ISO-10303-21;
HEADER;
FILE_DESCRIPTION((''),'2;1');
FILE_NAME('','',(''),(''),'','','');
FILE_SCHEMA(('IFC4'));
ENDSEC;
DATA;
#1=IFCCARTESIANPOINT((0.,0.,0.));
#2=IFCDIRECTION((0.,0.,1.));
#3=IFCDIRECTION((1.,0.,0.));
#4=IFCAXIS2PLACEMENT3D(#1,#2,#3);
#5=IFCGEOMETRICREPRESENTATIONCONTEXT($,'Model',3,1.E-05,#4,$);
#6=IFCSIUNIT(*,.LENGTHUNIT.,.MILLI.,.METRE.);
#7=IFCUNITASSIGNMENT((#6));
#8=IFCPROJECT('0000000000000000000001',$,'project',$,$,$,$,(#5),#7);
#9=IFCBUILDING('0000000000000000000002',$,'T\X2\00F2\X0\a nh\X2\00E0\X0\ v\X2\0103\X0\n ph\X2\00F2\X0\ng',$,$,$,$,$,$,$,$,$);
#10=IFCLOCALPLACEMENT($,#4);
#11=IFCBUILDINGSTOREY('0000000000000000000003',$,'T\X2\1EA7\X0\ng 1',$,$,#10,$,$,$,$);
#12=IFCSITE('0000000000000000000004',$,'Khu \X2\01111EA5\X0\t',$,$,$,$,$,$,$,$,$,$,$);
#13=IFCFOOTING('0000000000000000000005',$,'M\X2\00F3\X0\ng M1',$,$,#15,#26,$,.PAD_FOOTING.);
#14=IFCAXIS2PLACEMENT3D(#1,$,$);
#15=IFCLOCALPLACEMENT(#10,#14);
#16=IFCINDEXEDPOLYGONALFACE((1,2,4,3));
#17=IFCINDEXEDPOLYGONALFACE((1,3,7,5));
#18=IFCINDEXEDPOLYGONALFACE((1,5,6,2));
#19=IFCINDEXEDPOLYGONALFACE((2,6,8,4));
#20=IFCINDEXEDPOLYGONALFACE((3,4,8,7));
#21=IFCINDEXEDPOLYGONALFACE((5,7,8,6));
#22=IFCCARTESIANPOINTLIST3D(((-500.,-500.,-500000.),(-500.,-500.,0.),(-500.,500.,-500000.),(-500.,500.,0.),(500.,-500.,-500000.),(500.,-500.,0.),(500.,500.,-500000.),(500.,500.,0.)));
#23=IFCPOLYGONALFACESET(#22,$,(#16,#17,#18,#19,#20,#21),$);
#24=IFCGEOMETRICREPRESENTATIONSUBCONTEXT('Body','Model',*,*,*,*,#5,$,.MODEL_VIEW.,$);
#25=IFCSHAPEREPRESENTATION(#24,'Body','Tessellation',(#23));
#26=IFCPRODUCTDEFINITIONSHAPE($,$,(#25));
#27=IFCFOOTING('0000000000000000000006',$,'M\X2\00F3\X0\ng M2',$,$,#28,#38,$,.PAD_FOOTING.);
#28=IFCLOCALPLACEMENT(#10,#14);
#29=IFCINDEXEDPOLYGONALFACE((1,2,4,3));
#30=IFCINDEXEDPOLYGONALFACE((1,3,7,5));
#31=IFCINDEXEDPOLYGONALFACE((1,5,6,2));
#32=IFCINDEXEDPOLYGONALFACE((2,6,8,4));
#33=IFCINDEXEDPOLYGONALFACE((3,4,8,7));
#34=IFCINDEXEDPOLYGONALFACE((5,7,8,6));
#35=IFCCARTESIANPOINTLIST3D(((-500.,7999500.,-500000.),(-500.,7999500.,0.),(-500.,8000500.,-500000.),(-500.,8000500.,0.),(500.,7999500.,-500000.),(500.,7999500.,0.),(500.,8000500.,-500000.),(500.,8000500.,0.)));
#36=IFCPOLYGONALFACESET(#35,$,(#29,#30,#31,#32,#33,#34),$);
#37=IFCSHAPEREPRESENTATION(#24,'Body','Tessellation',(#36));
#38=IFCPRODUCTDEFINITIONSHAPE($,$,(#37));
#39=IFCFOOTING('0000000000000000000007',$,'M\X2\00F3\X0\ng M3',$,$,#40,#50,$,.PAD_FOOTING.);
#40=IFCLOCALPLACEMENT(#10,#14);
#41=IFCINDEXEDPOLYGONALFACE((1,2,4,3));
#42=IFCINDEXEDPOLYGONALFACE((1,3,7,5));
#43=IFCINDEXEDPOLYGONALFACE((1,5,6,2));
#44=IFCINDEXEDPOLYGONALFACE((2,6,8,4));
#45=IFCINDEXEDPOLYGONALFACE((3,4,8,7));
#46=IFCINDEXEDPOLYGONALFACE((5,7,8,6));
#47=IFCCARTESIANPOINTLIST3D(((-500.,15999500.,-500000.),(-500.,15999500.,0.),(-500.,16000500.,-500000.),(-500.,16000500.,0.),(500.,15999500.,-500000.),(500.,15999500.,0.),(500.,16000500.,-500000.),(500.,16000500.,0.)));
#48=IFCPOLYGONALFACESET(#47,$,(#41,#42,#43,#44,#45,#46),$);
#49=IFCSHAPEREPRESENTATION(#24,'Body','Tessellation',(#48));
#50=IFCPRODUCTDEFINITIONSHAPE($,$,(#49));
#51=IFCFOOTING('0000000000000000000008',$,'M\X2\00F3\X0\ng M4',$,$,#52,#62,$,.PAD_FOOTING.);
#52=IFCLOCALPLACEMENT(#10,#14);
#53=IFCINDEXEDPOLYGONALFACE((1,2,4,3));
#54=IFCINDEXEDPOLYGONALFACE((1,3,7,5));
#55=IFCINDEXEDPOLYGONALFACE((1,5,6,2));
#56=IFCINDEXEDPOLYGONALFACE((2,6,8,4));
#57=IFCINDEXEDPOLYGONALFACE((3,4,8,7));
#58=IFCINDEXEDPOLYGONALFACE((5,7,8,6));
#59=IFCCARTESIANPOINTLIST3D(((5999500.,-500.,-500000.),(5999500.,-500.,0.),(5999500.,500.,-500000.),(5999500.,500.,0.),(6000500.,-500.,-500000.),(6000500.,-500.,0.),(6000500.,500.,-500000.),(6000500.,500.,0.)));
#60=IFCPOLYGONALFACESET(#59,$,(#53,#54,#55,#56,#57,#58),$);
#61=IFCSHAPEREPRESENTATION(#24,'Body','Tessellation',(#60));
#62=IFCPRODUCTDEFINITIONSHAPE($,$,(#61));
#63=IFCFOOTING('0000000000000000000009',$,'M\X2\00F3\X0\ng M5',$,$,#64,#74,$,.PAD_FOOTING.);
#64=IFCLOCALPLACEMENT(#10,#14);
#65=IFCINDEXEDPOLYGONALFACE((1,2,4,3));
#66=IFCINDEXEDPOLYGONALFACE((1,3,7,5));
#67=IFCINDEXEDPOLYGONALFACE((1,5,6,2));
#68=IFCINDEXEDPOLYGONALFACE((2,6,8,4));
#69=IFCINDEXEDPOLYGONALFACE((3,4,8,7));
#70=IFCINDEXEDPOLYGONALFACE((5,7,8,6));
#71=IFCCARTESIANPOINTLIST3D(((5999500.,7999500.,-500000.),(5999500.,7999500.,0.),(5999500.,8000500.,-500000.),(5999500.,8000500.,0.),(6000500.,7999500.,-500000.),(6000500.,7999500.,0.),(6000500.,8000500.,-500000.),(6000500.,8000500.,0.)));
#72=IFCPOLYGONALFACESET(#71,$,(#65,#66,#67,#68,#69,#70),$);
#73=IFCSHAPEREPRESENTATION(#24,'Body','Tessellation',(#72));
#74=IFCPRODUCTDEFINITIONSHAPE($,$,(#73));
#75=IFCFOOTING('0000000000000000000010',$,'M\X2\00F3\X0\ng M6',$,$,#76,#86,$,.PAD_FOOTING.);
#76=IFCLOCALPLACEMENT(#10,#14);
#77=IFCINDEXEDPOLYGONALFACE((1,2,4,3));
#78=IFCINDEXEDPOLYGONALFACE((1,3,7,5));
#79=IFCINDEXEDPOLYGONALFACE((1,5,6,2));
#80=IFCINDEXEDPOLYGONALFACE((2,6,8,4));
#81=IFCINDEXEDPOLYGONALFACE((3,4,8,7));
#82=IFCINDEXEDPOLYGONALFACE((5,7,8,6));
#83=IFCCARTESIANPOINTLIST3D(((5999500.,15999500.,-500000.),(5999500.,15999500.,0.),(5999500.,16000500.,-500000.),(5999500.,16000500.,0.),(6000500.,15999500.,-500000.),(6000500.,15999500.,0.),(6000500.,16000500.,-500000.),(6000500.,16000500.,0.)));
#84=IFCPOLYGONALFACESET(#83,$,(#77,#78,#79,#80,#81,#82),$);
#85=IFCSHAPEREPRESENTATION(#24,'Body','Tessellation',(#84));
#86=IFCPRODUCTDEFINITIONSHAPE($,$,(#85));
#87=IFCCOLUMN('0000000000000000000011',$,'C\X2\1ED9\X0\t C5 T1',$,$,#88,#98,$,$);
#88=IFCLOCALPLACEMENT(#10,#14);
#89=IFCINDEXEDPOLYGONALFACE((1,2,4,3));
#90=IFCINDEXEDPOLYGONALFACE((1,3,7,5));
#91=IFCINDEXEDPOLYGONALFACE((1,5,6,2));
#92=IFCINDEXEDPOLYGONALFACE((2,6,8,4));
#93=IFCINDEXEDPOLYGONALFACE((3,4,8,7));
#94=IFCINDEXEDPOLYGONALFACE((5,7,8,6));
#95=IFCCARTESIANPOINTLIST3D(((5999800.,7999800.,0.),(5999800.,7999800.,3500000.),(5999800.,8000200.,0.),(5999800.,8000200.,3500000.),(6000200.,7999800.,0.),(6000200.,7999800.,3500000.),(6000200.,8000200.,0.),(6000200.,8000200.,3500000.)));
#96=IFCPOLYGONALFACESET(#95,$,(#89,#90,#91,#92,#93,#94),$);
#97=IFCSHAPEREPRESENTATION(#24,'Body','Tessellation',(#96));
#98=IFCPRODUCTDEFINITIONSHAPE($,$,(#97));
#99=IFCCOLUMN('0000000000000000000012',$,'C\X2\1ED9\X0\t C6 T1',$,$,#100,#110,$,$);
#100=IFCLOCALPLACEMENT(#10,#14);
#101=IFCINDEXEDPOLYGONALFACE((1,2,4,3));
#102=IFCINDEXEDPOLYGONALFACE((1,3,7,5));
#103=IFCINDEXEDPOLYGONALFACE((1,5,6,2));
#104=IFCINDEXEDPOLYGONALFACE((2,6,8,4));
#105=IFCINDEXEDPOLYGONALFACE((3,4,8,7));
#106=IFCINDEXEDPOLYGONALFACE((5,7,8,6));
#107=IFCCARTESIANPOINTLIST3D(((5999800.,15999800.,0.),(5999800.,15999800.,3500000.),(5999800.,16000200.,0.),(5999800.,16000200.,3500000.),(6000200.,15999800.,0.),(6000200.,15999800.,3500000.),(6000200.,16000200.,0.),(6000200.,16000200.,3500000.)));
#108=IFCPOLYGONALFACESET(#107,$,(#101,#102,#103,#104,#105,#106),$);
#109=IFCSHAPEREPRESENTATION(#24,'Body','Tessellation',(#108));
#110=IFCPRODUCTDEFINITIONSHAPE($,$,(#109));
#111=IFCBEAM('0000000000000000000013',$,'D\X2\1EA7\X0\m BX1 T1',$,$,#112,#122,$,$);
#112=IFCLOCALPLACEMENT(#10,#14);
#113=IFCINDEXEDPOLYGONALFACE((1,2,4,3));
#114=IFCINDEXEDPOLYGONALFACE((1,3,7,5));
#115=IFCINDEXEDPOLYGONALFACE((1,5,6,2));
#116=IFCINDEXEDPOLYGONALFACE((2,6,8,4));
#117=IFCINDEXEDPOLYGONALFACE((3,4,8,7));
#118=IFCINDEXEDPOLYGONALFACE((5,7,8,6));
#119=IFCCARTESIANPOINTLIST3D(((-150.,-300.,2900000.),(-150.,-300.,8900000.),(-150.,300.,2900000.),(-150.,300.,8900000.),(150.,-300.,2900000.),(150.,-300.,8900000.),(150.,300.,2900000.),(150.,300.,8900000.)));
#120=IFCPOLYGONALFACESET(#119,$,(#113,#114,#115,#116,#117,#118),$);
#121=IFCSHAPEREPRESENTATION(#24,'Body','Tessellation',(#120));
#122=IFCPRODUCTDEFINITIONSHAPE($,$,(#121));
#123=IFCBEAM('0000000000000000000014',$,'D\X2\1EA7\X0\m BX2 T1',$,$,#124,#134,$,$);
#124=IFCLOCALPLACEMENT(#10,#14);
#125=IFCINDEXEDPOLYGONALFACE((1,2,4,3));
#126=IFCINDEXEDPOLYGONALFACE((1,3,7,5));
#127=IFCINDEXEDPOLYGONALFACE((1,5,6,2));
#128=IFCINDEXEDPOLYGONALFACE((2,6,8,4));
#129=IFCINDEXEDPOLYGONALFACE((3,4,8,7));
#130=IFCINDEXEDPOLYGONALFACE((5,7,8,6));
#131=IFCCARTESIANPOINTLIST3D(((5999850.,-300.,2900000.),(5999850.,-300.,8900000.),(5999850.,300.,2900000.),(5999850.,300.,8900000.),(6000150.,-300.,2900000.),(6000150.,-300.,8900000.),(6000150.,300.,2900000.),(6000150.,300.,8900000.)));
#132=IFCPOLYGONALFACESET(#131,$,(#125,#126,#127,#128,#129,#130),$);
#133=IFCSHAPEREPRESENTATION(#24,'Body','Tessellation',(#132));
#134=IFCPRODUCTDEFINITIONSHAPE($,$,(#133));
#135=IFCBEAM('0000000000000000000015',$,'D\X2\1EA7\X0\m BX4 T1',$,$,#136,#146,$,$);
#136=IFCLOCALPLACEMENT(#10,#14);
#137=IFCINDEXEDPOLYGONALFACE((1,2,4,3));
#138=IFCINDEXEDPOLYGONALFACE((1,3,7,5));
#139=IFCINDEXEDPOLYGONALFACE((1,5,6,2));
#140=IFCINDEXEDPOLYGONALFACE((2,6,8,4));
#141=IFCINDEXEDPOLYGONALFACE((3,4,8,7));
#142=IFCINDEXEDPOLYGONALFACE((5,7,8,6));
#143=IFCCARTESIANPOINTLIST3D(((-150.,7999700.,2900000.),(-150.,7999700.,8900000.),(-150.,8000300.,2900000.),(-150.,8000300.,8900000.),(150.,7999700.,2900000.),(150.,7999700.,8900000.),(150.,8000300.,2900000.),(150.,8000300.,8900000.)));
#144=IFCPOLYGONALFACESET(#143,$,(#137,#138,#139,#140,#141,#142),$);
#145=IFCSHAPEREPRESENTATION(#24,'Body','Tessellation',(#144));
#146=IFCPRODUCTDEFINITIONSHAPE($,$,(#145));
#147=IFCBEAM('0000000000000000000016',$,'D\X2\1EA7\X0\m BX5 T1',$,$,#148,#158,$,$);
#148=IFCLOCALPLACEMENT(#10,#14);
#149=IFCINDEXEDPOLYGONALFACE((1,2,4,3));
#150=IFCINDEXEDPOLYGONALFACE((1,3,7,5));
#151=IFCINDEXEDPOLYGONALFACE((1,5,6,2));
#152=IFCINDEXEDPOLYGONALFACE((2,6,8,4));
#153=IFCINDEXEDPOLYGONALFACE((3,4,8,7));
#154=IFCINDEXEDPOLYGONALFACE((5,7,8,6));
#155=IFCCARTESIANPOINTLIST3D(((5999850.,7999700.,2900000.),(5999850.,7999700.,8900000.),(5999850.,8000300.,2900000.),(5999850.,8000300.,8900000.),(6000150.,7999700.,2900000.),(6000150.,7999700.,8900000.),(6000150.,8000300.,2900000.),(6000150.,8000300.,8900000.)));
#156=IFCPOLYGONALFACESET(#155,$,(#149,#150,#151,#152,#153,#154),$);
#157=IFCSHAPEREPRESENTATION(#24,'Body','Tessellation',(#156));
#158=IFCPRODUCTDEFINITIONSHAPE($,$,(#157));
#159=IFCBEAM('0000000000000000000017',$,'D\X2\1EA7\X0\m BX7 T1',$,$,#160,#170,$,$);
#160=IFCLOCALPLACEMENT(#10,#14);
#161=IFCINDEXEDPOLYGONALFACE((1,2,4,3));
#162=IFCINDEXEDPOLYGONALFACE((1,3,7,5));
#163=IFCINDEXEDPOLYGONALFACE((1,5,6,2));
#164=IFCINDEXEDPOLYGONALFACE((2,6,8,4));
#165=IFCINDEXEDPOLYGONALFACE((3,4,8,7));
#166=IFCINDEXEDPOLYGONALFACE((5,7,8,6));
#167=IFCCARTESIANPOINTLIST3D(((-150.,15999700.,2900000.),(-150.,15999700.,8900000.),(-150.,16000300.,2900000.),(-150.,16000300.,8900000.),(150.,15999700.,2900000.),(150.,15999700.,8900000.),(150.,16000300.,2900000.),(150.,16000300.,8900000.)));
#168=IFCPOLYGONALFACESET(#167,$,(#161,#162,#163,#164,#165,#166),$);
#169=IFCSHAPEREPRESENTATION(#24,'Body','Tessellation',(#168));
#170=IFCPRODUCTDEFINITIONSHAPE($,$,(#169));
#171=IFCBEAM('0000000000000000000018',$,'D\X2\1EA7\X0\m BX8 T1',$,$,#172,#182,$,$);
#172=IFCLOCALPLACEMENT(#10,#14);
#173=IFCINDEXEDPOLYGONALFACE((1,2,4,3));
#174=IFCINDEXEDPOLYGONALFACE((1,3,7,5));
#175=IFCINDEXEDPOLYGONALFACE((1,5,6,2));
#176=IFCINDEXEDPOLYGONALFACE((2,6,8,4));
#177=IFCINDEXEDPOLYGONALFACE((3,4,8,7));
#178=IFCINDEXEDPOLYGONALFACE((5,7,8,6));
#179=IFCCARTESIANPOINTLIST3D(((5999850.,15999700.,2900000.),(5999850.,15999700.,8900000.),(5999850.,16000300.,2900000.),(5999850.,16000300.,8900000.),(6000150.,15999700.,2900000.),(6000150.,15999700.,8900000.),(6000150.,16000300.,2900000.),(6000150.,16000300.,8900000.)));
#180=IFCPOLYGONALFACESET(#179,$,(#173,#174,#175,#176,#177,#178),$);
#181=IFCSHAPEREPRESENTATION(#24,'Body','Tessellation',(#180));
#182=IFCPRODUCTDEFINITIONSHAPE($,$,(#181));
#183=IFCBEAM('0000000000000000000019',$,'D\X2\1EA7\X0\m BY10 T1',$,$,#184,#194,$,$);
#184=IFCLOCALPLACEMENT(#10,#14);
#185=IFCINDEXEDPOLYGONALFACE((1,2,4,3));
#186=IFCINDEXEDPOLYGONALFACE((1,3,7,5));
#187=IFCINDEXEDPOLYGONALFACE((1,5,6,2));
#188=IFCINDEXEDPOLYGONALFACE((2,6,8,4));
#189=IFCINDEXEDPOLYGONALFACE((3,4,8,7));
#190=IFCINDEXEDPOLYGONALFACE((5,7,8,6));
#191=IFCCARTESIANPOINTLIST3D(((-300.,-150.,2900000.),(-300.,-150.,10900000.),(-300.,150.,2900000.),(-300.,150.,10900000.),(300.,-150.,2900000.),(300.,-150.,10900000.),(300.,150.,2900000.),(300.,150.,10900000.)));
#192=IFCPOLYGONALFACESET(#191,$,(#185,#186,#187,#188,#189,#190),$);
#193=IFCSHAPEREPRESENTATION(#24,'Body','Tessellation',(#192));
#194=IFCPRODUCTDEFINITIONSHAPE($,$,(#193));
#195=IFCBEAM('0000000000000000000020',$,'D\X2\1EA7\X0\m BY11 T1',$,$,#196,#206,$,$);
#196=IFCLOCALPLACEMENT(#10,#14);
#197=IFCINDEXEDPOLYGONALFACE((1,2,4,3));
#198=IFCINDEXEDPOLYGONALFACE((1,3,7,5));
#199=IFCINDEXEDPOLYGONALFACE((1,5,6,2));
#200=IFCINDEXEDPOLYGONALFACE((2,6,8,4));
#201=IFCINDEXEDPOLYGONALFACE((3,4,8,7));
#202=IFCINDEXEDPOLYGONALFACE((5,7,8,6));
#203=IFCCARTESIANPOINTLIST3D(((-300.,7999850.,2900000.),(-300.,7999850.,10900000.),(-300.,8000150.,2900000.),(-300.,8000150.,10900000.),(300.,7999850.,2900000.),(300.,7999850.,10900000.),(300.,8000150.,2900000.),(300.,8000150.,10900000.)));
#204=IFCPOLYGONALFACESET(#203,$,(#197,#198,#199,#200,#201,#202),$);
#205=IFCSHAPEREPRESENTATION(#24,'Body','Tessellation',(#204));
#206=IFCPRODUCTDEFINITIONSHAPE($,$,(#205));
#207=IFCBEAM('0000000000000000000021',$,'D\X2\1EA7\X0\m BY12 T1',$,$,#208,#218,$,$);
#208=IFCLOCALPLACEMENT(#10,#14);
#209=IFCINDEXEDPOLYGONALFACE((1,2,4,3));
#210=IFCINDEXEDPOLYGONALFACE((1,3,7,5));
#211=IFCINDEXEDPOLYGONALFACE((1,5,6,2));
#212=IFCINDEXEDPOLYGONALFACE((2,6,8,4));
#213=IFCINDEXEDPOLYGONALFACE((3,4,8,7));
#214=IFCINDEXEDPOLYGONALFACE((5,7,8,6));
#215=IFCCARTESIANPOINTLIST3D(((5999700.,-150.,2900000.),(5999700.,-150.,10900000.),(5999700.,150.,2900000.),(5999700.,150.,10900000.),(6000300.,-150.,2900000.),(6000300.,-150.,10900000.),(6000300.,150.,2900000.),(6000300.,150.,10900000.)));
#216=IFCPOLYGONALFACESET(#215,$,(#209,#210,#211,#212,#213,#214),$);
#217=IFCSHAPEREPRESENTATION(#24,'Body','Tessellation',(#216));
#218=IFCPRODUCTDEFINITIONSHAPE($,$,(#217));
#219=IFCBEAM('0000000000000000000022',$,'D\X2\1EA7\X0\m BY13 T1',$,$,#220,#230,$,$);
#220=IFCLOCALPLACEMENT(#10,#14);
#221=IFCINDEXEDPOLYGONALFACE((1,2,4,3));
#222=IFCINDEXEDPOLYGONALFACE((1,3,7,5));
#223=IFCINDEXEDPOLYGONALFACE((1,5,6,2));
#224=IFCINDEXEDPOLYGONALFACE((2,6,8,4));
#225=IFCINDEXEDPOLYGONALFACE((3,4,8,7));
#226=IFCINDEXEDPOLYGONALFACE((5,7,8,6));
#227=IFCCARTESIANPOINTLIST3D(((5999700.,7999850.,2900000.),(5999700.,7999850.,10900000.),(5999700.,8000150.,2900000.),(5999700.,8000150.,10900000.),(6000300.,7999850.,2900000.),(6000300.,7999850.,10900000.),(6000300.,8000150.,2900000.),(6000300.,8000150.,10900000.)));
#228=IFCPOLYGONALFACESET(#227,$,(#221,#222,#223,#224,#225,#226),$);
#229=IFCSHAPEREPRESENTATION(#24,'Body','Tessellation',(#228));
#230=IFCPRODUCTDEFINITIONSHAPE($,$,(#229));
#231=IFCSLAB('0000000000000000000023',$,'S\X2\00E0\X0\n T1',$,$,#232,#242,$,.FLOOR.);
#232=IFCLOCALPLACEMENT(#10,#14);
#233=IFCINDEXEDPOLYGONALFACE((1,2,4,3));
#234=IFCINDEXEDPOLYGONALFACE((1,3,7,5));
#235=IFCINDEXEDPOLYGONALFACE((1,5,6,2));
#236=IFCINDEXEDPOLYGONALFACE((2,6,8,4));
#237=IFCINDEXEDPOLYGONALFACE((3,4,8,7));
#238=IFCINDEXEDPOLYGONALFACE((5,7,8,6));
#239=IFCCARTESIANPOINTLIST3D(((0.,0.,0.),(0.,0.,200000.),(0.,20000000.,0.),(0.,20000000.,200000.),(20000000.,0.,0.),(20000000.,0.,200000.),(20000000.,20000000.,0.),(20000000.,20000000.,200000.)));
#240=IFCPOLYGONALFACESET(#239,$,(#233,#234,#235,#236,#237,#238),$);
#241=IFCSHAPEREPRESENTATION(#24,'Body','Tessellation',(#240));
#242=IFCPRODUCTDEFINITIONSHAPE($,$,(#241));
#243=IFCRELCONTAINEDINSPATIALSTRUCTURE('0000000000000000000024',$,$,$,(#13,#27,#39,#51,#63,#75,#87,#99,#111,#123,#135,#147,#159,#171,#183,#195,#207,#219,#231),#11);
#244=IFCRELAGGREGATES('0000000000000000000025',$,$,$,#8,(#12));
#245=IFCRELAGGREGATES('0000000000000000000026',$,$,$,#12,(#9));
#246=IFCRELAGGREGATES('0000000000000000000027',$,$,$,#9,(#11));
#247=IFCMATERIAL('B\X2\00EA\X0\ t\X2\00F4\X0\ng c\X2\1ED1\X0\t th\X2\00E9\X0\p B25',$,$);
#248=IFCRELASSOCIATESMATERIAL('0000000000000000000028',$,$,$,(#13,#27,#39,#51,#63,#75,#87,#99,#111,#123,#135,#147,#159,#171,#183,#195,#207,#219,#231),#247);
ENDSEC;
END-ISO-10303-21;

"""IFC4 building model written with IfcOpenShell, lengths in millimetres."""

from ifc_helpers import new_model, entity, si_unit, frame, origin_with_axes, place, context, subcontext, project, spatial, indexed_curve, outline, extrude, material, element, save


model = new_model("IFC4")

# Units and contexts
model_context = context("Model", 3, precision=1e-05, world=origin_with_axes())
body_context = subcontext(model_context, "Body", "Model", "MODEL_VIEW")
ifc_project = project(units=[si_unit("LENGTHUNIT", "METRE", prefix="MILLI")], contexts=[model_context])

# Site, building, storey
site = spatial("IfcSite", under=ifc_project, Name="Khu đất")
building = spatial("IfcBuilding", under=site, Name="Tòa nhà văn phòng")
storey_placement = place(None, origin_with_axes())
storey = spatial("IfcBuildingStorey", under=building, at=storey_placement, Name="Tầng 1")

# Footings
ifc_material_1 = material(Name="Bê tông cốt thép B25")
for number, where, z_axis, x_axis, name in (
    (1, (0.0, 0.0, -500000.0), (0.0, 0.0, 1.0), (1.0, 0.0, 0.0), "Móng M1"),
    (2, (0.0, 8000000.0, -500000.0), (0.0, 0.0, 1.0), (1.0, 0.0, 0.0), "Móng M2"),
    (3, (0.0, 16000000.0, -500000.0), (0.0, 0.0, 1.0), (1.0, 0.0, 0.0), "Móng M3"),
    (4, (6000000.0, 0.0, -500000.0), (0.0, 0.0, 1.0), (1.0, 0.0, 0.0), "Móng M4"),
    (5, (6000000.0, 8000000.0, -500000.0), (0.0, 0.0, 1.0), (1.0, 0.0, 0.0), "Móng M5"),
    (6, (6000000.0, 16000000.0, -500000.0), (0.0, 0.0, 1.0), (1.0, 0.0, 0.0), "Móng M6"),
):
    element("IfcFooting", number, at=place(storey_placement, frame(where, z_axis=z_axis, x_axis=x_axis)), inside=storey, material=ifc_material_1, Name=name, PredefinedType="PAD_FOOTING", context=body_context, shape_type="SweptSolid", body=[
        extrude(entity("IfcRectangleProfileDef", None, None, None, 1000.0, 1000.0), origin_with_axes(), (0.0, 0.0, 1.0), 500000.0),
    ])

# Columns
for number, where, z_axis, x_axis, name in (
    (7, (6000000.0, 8000000.0, 0.0), (0.0, 0.0, 1.0), (1.0, 0.0, 0.0), "Cột C5 T1"),
    (8, (6000000.0, 16000000.0, 0.0), (0.0, 0.0, 1.0), (1.0, 0.0, 0.0), "Cột C6 T1"),
):
    element("IfcColumn", number, at=place(storey_placement, frame(where, z_axis=z_axis, x_axis=x_axis)), inside=storey, material=ifc_material_1, Name=name, context=body_context, shape_type="SweptSolid", body=[
        extrude(entity("IfcRectangleProfileDef", None, None, None, 400.0, 400.0), origin_with_axes(), (0.0, 0.0, 1.0), 3500000.0),
    ])

# Beams
for number, where, z_axis, x_axis, name in (
    (9, (0.0, 0.0, 2900000.0), (0.0, 0.0, 1.0), (1.0, 0.0, 0.0), "Dầm BX1 T1"),
    (10, (6000000.0, 0.0, 2900000.0), (0.0, 0.0, 1.0), (1.0, 0.0, 0.0), "Dầm BX2 T1"),
    (11, (0.0, 8000000.0, 2900000.0), (0.0, 0.0, 1.0), (1.0, 0.0, 0.0), "Dầm BX4 T1"),
    (12, (6000000.0, 8000000.0, 2900000.0), (0.0, 0.0, 1.0), (1.0, 0.0, 0.0), "Dầm BX5 T1"),
    (13, (0.0, 16000000.0, 2900000.0), (0.0, 0.0, 1.0), (1.0, 0.0, 0.0), "Dầm BX7 T1"),
    (14, (6000000.0, 16000000.0, 2900000.0), (0.0, 0.0, 1.0), (1.0, 0.0, 0.0), "Dầm BX8 T1"),
):
    element("IfcBeam", number, at=place(storey_placement, frame(where, z_axis=z_axis, x_axis=x_axis)), inside=storey, material=ifc_material_1, Name=name, context=body_context, shape_type="SweptSolid", body=[
        extrude(entity("IfcRectangleProfileDef", None, None, None, 300.0, 600.0), origin_with_axes(), (0.0, 0.0, 1.0), 6000000.0),
    ])
for number, where, z_axis, x_axis, name in (
    (15, (0.0, 0.0, 2900000.0), (0.0, 0.0, 1.0), (0.0, 1.0, 0.0), "Dầm BY10 T1"),
    (16, (0.0, 8000000.0, 2900000.0), (0.0, 0.0, 1.0), (0.0, 1.0, 0.0), "Dầm BY11 T1"),
    (17, (6000000.0, 0.0, 2900000.0), (0.0, 0.0, 1.0), (0.0, 1.0, 0.0), "Dầm BY12 T1"),
    (18, (6000000.0, 8000000.0, 2900000.0), (0.0, 0.0, 1.0), (0.0, 1.0, 0.0), "Dầm BY13 T1"),
):
    element("IfcBeam", number, at=place(storey_placement, frame(where, z_axis=z_axis, x_axis=x_axis)), inside=storey, material=ifc_material_1, Name=name, context=body_context, shape_type="SweptSolid", body=[
        extrude(entity("IfcRectangleProfileDef", None, None, None, 300.0, 600.0), origin_with_axes(), (0.0, 0.0, 1.0), 8000000.0),
    ])

# Slab
slab_placement = place(storey_placement, origin_with_axes())
element("IfcSlab", 19, at=slab_placement, inside=storey, material=ifc_material_1, Name="Sàn T1", PredefinedType="FLOOR", context=body_context, shape_type="SweptSolid", body=[
    extrude(outline(indexed_curve([(0.0, 0.0), (20000000.0, 0.0), (20000000.0, 20000000.0), (0.0, 20000000.0), (0.0, 0.0)])), None, (0.0, 0.0, 1.0), 200000.0),
])

save(model, "model.ifc")
